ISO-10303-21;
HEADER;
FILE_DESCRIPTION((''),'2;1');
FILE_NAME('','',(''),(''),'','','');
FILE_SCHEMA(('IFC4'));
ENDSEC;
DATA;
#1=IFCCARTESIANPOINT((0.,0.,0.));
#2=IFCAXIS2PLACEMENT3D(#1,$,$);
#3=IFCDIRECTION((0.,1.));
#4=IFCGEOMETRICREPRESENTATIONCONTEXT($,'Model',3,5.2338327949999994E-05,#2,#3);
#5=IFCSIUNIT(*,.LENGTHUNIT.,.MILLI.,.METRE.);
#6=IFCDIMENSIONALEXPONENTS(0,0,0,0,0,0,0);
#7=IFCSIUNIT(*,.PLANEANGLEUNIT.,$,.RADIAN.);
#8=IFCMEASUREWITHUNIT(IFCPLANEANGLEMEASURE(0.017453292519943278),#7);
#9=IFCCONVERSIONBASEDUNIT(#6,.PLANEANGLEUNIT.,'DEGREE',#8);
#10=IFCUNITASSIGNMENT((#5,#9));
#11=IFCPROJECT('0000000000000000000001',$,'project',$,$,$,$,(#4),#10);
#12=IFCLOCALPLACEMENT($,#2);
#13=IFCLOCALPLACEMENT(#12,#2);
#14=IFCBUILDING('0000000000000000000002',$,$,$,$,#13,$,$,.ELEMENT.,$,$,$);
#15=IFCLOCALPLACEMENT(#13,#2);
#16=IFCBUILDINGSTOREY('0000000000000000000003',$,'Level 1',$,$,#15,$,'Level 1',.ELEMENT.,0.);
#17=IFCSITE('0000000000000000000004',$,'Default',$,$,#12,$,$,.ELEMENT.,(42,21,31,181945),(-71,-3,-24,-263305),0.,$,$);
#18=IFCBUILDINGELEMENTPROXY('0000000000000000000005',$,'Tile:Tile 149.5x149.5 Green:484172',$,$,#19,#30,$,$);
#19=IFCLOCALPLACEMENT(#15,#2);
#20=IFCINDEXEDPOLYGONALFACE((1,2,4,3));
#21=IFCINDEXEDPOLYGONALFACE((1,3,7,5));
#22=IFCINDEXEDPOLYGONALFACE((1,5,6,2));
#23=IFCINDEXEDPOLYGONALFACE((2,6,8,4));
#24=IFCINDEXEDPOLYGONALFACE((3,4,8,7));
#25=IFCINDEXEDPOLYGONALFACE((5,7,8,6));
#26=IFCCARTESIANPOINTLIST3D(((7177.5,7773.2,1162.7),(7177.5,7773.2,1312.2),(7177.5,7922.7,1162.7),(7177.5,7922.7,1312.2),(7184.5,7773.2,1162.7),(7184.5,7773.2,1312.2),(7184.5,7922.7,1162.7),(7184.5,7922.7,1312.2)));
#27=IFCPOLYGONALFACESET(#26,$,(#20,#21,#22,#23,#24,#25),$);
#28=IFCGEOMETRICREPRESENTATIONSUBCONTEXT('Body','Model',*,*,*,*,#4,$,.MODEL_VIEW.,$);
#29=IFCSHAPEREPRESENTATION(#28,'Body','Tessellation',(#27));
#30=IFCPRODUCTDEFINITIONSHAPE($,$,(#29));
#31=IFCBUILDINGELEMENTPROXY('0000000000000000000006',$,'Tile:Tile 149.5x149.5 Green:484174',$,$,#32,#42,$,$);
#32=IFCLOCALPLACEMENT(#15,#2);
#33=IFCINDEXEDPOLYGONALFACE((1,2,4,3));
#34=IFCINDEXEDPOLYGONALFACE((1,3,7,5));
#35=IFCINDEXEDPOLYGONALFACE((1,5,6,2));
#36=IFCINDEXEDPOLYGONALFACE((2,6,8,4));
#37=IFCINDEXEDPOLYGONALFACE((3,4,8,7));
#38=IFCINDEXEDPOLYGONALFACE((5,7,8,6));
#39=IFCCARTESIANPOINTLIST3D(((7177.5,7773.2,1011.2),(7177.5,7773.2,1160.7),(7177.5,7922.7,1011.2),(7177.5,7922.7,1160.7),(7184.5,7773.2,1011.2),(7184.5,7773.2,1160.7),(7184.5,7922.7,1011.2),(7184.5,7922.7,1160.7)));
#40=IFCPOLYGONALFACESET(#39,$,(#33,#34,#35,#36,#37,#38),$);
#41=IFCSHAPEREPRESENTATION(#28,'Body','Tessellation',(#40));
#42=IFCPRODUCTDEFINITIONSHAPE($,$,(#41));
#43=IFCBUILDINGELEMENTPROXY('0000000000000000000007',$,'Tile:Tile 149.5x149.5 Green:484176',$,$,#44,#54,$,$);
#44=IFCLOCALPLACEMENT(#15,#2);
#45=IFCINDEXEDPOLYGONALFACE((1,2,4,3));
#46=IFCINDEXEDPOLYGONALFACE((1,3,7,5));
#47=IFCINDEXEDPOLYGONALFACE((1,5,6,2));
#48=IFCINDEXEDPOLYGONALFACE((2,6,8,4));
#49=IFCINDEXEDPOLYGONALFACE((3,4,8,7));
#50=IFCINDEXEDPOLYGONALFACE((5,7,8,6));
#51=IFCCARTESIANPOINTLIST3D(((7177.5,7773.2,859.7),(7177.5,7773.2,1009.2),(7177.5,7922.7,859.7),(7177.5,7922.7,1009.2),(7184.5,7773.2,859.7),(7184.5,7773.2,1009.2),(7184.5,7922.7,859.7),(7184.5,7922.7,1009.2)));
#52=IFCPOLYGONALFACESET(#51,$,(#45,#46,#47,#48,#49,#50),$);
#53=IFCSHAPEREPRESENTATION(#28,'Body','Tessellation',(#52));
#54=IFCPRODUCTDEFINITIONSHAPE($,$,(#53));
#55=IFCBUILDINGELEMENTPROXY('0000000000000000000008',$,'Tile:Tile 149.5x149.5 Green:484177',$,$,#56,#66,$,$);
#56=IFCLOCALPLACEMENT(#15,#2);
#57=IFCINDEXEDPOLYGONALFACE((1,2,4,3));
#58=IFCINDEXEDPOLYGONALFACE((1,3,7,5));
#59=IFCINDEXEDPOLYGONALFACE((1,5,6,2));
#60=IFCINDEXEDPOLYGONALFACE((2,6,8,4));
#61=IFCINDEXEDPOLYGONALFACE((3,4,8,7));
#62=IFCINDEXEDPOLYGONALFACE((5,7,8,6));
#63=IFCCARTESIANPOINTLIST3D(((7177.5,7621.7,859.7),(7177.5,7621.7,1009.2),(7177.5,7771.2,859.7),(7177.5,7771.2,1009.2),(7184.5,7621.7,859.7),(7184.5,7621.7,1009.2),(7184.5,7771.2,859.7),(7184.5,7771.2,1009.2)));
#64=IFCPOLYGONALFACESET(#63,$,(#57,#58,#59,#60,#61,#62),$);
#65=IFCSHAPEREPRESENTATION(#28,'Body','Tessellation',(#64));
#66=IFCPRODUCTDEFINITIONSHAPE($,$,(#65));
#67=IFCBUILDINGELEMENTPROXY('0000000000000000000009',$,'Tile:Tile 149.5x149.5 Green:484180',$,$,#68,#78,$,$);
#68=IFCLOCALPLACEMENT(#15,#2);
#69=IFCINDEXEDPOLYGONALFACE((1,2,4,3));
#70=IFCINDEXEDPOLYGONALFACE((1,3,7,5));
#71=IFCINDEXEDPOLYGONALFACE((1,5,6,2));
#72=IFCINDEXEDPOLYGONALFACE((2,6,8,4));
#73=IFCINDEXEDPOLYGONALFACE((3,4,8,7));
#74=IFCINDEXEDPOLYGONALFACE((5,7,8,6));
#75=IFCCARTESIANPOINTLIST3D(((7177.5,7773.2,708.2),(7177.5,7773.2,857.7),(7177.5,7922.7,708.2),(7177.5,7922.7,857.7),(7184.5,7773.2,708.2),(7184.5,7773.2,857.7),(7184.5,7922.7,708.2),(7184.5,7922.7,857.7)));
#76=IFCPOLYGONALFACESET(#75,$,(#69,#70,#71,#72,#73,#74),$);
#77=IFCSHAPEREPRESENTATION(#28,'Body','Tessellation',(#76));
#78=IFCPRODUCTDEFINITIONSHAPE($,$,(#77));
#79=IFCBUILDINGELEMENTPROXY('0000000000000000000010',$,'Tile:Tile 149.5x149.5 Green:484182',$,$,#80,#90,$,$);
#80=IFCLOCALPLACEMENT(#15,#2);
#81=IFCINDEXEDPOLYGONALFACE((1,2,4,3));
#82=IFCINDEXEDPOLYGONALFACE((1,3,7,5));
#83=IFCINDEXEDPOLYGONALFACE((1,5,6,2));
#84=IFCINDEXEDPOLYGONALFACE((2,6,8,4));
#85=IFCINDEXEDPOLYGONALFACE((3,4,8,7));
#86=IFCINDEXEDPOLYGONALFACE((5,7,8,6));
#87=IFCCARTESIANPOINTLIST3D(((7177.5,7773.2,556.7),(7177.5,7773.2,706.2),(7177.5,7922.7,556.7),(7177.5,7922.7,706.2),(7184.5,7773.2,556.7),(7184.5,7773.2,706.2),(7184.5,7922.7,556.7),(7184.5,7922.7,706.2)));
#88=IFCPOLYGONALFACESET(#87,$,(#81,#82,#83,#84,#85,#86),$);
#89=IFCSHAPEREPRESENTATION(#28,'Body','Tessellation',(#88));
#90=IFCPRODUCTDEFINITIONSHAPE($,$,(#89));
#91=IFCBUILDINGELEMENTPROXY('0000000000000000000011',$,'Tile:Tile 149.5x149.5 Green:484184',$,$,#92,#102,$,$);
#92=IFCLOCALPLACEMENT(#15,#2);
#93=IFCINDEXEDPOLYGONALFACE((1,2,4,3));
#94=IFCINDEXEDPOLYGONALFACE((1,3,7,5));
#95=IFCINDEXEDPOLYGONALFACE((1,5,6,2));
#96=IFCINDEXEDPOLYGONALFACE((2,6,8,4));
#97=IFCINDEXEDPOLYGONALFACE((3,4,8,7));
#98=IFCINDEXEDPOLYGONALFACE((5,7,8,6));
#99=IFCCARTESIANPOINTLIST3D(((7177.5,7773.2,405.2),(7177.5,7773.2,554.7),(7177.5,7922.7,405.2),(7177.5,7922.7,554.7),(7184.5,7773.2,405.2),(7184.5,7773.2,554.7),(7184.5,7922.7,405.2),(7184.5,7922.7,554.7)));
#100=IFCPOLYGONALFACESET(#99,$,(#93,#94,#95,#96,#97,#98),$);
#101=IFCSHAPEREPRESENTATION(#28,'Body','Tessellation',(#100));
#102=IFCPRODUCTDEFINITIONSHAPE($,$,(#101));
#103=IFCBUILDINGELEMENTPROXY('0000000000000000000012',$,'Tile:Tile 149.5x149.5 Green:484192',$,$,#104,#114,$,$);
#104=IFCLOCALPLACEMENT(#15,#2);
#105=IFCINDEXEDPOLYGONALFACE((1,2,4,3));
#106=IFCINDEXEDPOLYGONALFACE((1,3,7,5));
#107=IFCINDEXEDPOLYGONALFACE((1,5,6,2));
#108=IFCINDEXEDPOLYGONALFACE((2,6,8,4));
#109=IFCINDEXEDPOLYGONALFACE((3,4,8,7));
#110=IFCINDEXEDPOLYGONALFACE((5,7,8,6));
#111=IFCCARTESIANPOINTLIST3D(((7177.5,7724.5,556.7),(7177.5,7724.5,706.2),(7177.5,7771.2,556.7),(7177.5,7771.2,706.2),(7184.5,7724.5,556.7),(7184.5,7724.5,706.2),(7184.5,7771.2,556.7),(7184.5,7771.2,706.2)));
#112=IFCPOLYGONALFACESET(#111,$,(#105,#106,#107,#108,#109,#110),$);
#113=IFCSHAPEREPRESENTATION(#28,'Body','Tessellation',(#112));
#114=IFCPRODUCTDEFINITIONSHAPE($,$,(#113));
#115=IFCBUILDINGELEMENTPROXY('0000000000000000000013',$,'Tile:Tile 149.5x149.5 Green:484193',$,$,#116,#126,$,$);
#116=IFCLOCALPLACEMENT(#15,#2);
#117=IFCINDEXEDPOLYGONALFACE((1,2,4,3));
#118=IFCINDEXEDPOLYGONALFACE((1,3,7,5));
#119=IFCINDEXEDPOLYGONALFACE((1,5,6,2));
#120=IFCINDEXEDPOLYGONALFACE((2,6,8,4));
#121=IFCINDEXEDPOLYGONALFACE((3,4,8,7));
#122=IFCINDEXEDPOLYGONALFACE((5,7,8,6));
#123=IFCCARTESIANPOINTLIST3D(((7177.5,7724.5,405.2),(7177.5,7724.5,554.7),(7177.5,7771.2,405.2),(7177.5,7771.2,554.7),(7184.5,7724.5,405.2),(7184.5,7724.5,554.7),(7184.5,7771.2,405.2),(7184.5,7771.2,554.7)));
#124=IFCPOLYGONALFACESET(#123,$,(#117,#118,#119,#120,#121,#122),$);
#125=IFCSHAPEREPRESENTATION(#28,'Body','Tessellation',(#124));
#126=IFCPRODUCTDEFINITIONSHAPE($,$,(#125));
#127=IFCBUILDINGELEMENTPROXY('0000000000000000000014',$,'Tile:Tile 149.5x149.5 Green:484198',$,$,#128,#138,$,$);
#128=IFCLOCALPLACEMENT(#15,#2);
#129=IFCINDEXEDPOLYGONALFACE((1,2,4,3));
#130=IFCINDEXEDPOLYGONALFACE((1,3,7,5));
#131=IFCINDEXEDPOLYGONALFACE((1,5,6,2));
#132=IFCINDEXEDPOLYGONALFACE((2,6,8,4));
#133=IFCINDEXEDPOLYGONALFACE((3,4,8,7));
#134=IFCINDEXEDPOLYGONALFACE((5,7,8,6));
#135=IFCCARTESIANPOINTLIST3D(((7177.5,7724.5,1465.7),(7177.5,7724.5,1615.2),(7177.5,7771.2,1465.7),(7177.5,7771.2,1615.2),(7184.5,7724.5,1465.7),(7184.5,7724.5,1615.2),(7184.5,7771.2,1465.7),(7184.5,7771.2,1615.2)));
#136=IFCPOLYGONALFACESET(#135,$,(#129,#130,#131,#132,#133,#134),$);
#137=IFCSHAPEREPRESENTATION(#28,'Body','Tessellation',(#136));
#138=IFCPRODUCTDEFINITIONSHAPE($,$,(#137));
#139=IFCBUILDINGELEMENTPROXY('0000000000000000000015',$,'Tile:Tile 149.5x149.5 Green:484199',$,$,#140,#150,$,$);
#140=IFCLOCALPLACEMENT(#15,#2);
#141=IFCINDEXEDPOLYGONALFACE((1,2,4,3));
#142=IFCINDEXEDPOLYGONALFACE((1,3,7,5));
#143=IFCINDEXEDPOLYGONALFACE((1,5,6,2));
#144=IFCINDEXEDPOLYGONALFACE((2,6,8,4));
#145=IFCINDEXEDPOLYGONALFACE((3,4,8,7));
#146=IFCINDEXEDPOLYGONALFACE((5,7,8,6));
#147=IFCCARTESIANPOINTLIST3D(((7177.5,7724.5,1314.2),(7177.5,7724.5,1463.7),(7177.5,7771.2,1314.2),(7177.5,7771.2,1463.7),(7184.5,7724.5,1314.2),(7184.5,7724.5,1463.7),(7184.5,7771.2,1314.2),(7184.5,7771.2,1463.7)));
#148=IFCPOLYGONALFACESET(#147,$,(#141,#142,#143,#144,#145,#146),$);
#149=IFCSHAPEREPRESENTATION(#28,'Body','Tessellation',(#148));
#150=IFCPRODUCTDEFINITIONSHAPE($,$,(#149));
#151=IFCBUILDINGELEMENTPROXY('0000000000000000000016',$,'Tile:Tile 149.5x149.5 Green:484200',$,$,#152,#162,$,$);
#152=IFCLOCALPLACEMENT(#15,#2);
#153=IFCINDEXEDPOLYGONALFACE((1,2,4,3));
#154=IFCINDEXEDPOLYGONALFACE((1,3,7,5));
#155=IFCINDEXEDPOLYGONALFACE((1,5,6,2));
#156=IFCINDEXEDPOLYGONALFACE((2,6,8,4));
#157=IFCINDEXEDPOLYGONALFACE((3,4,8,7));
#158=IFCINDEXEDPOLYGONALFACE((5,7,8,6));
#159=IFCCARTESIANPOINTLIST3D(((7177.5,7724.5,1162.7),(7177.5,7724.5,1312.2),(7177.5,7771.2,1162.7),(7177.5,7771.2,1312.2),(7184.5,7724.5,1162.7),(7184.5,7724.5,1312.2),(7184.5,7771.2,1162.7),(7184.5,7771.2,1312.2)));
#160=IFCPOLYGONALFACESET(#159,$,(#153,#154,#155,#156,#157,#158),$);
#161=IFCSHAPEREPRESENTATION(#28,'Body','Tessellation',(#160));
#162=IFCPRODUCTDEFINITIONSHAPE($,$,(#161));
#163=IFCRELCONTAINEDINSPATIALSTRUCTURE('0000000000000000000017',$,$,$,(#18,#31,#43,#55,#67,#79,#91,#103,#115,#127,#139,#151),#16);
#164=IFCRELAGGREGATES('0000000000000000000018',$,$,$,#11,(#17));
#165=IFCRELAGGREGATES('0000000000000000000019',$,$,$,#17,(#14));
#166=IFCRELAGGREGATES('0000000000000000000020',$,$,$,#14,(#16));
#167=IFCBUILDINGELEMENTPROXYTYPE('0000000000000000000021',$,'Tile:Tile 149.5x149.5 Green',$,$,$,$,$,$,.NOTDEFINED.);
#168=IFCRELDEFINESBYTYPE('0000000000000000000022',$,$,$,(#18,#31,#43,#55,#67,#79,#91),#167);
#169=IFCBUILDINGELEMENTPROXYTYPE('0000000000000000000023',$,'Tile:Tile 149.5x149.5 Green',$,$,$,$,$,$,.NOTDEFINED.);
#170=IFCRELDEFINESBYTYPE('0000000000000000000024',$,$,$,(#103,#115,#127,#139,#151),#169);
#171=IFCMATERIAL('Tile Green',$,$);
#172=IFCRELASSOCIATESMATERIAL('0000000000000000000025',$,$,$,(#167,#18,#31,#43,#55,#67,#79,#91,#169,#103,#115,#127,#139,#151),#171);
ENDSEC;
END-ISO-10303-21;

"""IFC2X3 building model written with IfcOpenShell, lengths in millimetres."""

from ifc_helpers import new_model, entity, si_unit, converted_unit, direction, frame, origin, origin_2d_with_axis, place, context, subcontext, project, spatial, rectangle, extrude, source, transform, mapped, material, type_object, type_shapes, element, save


model = new_model("IFC2X3")

# Units and contexts
model_context = context("Model", 3, precision=5.2338327949999994e-05, world=origin(), true_north=direction((0.0, 1.0)))
body_context = subcontext(model_context, "Body", "Model", "MODEL_VIEW")
ifc_project = project(units=[si_unit("LENGTHUNIT", "METRE", prefix="MILLI"), converted_unit("PLANEANGLEUNIT", "DEGREE", entity("IfcPlaneAngleMeasure", 0.017453292519943278), si_unit("PLANEANGLEUNIT", "RADIAN"), dimensions=[0, 0, 0, 0, 0, 0, 0])], contexts=[model_context])

# Site, building, storey
site_placement = place(None, origin())
site = spatial("IfcSite", under=ifc_project, at=site_placement, Name="Default", CompositionType="ELEMENT", RefLatitude=(42, 21, 31, 181945), RefLongitude=(-71, -3, -24, -263305), RefElevation=0.0)
building_placement = place(site_placement, origin())
building = spatial("IfcBuilding", under=site, at=building_placement, CompositionType="ELEMENT")
storey_placement = place(building_placement, origin())
storey = spatial("IfcBuildingStorey", under=building, at=storey_placement, Name="Level 1", LongName="Level 1", CompositionType="ELEMENT", Elevation=0.0)

# Building element proxies
ifc_material_1 = material(Name="Tile Green")
building_element_proxy_type_1 = type_object("IfcBuildingElementProxyType", Name="Tile:Tile 149.5x149.5 Green", PredefinedType="NOTDEFINED", material=ifc_material_1)
shared_shape_1 = source(origin(), body_context, "Body", "SweptSolid", [
    extrude(rectangle(XDim=149.5, YDim=149.5, at=origin_2d_with_axis()), frame((-74.7, -74.8, 0.0), z_axis=(0.0, 0.0, 1.0), x_axis=(0.0, -1.0, 0.0)), (0.0, 0.0, 1.0), 7.0),
])
type_shapes(building_element_proxy_type_1, [shared_shape_1])
for number, where, z_axis, x_axis, name in (
    (1, (7184.5, 7922.7, 1312.2), (-1.0, 0.0, 0.0), (0.0, 0.0, 1.0), "Tile:Tile 149.5x149.5 Green:484172"),
    (2, (7184.5, 7922.7, 1160.7), (-1.0, 0.0, 0.0), (0.0, 0.0, 1.0), "Tile:Tile 149.5x149.5 Green:484174"),
    (3, (7184.5, 7922.7, 1009.2), (-1.0, 0.0, 0.0), (0.0, 0.0, 1.0), "Tile:Tile 149.5x149.5 Green:484176"),
    (4, (7184.5, 7771.2, 1009.2), (-1.0, 0.0, 0.0), (0.0, 0.0, 1.0), "Tile:Tile 149.5x149.5 Green:484177"),
    (5, (7184.5, 7922.7, 857.7), (-1.0, 0.0, 0.0), (0.0, 0.0, 1.0), "Tile:Tile 149.5x149.5 Green:484180"),
    (6, (7184.5, 7922.7, 706.2), (-1.0, 0.0, 0.0), (0.0, 0.0, 1.0), "Tile:Tile 149.5x149.5 Green:484182"),
    (7, (7184.5, 7922.7, 554.7), (-1.0, 0.0, 0.0), (0.0, 0.0, 1.0), "Tile:Tile 149.5x149.5 Green:484184"),
):
    element("IfcBuildingElementProxy", number, at=place(storey_placement, frame(where, z_axis=z_axis, x_axis=x_axis)), inside=storey, type_object=building_element_proxy_type_1, material=ifc_material_1, Name=name, context=body_context, shape_type="MappedRepresentation", body=[
        mapped(shared_shape_1, transform((0.0, 0.0, 0.0), scale=1.0)),
    ])
building_element_proxy_type_2 = type_object("IfcBuildingElementProxyType", Name="Tile:Tile 149.5x149.5 Green", PredefinedType="NOTDEFINED", material=ifc_material_1)
shared_shape_2 = source(origin(), body_context, "Body", "SweptSolid", [
    extrude(rectangle(XDim=46.7, YDim=149.5, at=origin_2d_with_axis()), frame((-23.3, -74.8, 0.0), z_axis=(0.0, 0.0, 1.0), x_axis=(-1.0, 0.0, 0.0)), (0.0, 0.0, 1.0), 7.0),
])
type_shapes(building_element_proxy_type_2, [shared_shape_2])
for number, where, z_axis, x_axis, name in (
    (8, (7184.5, 7771.2, 556.7), (-1.0, 0.0, 0.0), (0.0, 1.0, 0.0), "Tile:Tile 149.5x149.5 Green:484192"),
    (9, (7184.5, 7771.2, 405.2), (-1.0, 0.0, 0.0), (0.0, 1.0, 0.0), "Tile:Tile 149.5x149.5 Green:484193"),
    (10, (7184.5, 7771.2, 1465.7), (-1.0, 0.0, 0.0), (0.0, 1.0, 0.0), "Tile:Tile 149.5x149.5 Green:484198"),
    (11, (7184.5, 7771.2, 1314.2), (-1.0, 0.0, 0.0), (0.0, 1.0, 0.0), "Tile:Tile 149.5x149.5 Green:484199"),
    (12, (7184.5, 7771.2, 1162.7), (-1.0, 0.0, 0.0), (0.0, 1.0, 0.0), "Tile:Tile 149.5x149.5 Green:484200"),
):
    element("IfcBuildingElementProxy", number, at=place(storey_placement, frame(where, z_axis=z_axis, x_axis=x_axis)), inside=storey, type_object=building_element_proxy_type_2, material=ifc_material_1, Name=name, context=body_context, shape_type="MappedRepresentation", body=[
        mapped(shared_shape_2, transform((0.0, 0.0, 0.0), scale=1.0)),
    ])

save(model, "model.ifc")
